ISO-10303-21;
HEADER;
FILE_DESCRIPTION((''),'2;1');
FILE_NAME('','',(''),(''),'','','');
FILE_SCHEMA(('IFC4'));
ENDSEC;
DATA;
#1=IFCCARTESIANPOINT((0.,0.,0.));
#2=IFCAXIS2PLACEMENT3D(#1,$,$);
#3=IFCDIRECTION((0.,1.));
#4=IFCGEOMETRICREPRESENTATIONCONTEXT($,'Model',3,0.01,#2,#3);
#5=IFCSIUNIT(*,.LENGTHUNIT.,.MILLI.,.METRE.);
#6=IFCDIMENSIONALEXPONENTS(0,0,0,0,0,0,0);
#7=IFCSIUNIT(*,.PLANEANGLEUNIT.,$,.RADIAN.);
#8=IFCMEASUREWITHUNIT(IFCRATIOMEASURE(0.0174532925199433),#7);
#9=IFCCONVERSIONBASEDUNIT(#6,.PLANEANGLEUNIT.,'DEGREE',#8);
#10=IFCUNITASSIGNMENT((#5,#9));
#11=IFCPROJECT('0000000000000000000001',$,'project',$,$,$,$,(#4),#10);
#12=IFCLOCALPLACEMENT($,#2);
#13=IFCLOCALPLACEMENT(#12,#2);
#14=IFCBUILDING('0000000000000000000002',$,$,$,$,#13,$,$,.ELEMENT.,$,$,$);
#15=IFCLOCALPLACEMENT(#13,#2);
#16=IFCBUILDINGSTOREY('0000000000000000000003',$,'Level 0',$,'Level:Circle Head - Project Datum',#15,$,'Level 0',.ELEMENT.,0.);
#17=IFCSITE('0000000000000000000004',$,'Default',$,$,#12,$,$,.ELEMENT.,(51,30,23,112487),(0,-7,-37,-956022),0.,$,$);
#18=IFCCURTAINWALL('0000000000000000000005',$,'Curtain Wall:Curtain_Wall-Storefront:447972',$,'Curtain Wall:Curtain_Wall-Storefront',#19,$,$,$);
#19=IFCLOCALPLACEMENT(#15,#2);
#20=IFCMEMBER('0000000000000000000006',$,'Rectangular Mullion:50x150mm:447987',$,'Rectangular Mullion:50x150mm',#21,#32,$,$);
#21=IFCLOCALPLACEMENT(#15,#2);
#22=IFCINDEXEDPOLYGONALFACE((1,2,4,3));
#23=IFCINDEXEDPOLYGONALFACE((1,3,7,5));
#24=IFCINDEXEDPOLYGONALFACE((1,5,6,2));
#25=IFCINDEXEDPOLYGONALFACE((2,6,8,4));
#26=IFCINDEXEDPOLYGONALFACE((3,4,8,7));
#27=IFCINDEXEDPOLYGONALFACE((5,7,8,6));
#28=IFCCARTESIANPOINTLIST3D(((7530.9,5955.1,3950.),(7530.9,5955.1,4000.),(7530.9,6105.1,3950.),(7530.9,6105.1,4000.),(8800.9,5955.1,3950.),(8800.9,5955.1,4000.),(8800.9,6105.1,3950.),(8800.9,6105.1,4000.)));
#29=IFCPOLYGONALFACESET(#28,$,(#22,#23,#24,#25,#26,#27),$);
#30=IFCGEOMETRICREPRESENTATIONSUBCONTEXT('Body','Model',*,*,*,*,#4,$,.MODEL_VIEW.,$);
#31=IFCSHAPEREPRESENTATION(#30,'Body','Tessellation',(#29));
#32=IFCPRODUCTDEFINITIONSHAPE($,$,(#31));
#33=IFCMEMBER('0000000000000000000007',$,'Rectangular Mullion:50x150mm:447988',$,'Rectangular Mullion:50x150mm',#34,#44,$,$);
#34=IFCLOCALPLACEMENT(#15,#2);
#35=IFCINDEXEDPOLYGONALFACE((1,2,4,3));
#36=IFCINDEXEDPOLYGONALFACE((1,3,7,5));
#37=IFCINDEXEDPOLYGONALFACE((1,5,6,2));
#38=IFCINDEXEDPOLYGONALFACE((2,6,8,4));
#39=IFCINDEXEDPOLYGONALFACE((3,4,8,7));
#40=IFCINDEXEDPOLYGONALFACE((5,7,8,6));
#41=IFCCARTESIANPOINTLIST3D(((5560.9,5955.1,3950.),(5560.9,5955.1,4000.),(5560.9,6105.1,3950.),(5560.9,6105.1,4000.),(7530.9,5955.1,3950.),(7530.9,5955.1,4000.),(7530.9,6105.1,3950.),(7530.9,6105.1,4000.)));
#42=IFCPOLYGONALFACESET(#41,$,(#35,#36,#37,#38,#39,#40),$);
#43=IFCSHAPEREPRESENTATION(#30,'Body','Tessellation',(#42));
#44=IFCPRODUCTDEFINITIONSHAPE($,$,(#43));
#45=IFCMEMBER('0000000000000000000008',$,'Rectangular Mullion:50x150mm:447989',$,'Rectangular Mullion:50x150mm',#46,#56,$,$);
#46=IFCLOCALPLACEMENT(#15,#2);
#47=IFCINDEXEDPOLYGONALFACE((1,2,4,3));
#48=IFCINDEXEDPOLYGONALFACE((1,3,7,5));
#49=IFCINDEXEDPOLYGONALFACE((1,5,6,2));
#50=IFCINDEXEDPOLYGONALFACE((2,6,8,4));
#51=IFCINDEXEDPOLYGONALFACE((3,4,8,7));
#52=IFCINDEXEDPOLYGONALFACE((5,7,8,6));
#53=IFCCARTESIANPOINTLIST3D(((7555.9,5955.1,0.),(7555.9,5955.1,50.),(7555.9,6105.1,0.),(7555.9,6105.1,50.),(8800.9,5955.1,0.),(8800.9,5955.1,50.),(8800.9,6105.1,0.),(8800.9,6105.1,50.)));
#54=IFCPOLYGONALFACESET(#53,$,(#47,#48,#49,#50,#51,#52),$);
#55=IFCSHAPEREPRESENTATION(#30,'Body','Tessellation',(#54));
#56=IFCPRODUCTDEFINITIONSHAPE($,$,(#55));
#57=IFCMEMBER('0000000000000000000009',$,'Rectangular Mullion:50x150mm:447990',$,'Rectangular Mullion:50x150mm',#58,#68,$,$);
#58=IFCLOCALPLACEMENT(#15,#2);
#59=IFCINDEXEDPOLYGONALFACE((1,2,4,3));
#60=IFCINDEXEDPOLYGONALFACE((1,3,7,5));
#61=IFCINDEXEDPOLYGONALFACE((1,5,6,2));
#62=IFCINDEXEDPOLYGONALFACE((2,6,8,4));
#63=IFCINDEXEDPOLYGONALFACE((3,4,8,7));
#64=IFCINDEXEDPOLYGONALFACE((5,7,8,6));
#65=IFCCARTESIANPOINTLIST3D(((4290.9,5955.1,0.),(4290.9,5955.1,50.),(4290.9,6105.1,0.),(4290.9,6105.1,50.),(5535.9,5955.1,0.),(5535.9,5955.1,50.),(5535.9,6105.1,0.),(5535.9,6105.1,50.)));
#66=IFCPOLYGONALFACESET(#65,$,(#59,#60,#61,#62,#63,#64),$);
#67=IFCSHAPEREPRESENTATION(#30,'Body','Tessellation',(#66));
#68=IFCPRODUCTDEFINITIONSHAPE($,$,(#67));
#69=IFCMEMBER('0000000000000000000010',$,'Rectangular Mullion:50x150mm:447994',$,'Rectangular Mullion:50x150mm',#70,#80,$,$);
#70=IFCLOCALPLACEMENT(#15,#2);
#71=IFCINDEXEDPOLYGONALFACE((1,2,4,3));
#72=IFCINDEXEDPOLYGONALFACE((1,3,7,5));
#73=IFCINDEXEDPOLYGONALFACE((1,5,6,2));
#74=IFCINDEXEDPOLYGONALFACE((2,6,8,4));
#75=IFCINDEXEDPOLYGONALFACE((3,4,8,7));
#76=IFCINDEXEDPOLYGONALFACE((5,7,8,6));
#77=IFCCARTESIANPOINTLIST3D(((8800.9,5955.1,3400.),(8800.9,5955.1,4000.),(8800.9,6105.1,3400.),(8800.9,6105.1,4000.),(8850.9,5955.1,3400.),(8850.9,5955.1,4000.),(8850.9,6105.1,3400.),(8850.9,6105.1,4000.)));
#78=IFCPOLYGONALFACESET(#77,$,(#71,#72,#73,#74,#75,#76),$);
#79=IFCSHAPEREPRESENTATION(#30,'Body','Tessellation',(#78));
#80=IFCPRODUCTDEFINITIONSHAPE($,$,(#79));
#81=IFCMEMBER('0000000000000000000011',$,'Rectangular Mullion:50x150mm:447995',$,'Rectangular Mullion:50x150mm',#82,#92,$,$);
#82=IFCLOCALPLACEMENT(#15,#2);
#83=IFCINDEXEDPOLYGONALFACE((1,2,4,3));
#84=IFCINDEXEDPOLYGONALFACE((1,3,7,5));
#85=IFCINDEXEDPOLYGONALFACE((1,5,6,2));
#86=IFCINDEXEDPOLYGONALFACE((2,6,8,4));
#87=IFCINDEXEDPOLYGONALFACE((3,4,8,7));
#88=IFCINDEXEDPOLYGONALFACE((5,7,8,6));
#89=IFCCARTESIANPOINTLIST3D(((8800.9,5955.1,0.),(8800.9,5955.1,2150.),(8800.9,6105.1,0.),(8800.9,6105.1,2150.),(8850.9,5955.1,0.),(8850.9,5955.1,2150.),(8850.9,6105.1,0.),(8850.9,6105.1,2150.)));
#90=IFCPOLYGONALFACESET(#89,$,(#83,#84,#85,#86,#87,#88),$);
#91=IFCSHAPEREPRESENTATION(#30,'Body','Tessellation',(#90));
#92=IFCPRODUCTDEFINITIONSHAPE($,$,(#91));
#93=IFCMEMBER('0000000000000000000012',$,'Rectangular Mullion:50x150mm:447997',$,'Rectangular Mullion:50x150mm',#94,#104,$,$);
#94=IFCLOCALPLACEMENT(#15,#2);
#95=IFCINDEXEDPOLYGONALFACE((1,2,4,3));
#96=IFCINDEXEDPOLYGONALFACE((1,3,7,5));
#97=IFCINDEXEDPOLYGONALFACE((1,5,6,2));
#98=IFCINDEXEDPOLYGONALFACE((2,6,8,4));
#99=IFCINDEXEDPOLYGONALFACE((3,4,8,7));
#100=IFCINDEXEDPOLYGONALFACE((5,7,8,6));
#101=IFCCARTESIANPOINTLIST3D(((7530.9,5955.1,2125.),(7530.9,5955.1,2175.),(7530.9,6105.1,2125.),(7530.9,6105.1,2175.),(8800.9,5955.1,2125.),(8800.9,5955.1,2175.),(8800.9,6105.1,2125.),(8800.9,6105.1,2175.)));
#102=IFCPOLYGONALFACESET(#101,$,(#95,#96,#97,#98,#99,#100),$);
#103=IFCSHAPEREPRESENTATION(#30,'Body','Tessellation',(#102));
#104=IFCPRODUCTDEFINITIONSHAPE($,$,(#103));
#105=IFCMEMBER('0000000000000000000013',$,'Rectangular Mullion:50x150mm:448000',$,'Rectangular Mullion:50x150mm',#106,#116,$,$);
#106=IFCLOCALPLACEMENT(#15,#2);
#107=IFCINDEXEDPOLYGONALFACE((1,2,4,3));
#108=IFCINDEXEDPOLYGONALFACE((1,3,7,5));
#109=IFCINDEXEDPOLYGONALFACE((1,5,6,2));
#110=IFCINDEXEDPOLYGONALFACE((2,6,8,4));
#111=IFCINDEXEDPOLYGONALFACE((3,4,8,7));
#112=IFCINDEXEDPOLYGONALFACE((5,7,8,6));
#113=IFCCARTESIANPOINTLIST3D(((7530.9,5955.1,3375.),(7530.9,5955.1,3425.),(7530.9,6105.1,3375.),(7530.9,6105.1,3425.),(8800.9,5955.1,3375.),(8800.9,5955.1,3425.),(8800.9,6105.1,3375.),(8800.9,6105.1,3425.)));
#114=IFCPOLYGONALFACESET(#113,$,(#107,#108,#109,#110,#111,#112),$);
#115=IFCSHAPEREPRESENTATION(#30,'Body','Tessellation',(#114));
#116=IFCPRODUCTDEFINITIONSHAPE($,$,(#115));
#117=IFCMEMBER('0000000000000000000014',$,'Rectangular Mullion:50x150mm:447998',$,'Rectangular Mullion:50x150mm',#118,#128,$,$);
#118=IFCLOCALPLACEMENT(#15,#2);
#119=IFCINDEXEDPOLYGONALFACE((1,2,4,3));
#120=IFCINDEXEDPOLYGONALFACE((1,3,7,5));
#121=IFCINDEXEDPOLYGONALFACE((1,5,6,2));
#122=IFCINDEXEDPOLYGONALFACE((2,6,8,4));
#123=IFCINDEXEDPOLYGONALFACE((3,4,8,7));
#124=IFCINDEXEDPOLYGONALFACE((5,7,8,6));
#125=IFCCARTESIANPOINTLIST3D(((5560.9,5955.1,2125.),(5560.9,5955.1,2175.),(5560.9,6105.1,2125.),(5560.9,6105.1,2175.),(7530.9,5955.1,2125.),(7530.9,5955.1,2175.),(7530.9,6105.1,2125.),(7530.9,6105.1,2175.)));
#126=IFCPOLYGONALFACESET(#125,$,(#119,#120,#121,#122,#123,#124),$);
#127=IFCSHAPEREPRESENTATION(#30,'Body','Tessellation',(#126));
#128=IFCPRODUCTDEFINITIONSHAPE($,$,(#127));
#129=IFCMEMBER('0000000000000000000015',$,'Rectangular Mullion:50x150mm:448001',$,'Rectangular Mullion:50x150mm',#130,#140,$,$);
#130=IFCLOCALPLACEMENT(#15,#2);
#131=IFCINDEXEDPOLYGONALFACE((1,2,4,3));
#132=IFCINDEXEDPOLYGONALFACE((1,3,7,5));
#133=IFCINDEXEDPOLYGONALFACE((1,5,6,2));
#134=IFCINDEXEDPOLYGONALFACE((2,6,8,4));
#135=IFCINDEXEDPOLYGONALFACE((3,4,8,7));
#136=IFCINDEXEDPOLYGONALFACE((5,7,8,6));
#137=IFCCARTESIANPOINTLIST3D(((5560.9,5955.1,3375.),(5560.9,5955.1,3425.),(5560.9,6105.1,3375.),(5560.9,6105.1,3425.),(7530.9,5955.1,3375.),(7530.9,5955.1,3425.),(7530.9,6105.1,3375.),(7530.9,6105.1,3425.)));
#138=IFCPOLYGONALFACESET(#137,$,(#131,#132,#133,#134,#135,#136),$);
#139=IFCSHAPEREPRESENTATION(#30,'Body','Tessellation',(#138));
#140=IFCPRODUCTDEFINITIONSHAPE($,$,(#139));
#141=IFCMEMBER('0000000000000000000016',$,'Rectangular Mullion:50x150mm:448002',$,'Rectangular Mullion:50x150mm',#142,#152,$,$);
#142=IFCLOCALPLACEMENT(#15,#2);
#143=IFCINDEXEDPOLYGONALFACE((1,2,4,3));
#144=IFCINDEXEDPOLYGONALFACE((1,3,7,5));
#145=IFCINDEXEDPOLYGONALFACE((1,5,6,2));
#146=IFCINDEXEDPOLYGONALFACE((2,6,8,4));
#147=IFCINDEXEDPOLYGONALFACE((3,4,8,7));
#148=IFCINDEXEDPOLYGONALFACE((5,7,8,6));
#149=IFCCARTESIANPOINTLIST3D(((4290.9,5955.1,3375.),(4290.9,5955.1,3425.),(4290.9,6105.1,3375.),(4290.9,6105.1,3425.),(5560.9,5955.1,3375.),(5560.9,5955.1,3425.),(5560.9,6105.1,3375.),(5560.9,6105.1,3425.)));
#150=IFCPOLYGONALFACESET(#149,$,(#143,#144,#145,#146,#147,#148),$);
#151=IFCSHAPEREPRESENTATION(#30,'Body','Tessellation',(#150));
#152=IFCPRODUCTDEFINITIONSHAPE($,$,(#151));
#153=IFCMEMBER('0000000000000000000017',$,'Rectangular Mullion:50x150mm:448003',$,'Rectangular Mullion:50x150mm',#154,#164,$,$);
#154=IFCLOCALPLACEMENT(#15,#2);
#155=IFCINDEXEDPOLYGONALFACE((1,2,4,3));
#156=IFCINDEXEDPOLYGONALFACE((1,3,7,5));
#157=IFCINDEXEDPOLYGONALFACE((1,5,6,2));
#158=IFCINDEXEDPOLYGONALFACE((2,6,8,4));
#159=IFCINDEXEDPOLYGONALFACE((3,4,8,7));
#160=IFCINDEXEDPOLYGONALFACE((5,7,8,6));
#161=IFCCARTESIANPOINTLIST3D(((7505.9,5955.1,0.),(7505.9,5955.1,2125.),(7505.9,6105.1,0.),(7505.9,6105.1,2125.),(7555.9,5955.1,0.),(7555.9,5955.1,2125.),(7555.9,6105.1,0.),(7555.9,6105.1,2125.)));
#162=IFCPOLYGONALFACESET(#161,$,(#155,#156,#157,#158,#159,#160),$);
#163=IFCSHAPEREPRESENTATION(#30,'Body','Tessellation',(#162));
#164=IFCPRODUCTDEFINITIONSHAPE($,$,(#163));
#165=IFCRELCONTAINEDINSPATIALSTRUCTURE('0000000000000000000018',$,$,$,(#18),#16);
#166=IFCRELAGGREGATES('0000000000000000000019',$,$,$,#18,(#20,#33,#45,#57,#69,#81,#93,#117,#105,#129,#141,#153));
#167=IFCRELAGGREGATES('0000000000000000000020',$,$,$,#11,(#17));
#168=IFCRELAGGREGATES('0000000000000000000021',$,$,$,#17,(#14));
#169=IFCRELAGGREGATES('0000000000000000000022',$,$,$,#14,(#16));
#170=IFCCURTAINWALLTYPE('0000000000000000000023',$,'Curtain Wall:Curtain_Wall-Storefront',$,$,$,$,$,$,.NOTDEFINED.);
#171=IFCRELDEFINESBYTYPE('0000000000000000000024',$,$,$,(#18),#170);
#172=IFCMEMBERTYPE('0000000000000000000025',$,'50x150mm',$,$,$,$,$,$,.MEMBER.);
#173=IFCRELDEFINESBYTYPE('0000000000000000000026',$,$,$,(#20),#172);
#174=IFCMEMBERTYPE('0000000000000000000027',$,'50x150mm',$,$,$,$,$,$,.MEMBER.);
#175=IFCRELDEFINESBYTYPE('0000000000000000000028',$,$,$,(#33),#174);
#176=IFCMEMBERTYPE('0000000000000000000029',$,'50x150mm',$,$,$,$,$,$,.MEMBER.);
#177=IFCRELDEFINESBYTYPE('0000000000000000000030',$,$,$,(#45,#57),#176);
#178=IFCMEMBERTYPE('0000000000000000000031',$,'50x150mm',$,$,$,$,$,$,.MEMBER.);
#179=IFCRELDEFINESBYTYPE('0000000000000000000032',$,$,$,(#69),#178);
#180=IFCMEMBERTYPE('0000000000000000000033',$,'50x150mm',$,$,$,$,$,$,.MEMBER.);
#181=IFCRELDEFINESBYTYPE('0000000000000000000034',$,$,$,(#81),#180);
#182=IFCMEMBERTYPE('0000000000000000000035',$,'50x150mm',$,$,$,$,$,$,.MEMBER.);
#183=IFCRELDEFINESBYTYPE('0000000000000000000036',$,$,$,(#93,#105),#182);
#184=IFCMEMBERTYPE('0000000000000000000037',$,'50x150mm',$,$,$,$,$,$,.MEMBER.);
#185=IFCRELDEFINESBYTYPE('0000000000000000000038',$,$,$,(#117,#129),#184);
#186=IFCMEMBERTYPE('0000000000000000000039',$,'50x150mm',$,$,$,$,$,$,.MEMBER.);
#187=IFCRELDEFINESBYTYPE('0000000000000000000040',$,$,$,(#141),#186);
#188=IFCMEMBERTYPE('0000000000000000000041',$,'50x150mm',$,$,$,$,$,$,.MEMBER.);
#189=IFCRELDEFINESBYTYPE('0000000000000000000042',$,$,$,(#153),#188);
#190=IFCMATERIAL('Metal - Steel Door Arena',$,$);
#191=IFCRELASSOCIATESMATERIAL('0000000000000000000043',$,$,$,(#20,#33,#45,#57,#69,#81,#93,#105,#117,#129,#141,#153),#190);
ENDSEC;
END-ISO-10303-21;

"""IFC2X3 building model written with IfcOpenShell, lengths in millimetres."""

from ifc_helpers import new_model, entity, si_unit, converted_unit, direction, frame, origin, origin_2d_with_axis, place, context, subcontext, project, spatial, rectangle, extrude, source, transform, mapped, material, type_object, type_shapes, element, aggregate, save


model = new_model("IFC2X3")

# Units and contexts
model_context = context("Model", 3, precision=0.01, world=origin(), true_north=direction((0.0, 1.0)))
body_context = subcontext(model_context, "Body", "Model", "MODEL_VIEW")
ifc_project = project(units=[si_unit("LENGTHUNIT", "METRE", prefix="MILLI"), converted_unit("PLANEANGLEUNIT", "DEGREE", entity("IfcRatioMeasure", 0.0174532925199433), si_unit("PLANEANGLEUNIT", "RADIAN"), dimensions=[0, 0, 0, 0, 0, 0, 0])], contexts=[model_context])

# Site, building, storey
site_placement = place(None, origin())
site = spatial("IfcSite", under=ifc_project, at=site_placement, Name="Default", CompositionType="ELEMENT", RefLatitude=(51, 30, 23, 112487), RefLongitude=(0, -7, -37, -956022), RefElevation=0.0)
building_placement = place(site_placement, origin())
building = spatial("IfcBuilding", under=site, at=building_placement, CompositionType="ELEMENT")
storey_placement = place(building_placement, origin())
storey = spatial("IfcBuildingStorey", under=building, at=storey_placement, Name="Level 0", ObjectType="Level:Circle Head - Project Datum", LongName="Level 0", CompositionType="ELEMENT", Elevation=0.0)

# Curtain wall, members
curtain_wall_type = type_object("IfcCurtainWallType", Name="Curtain Wall:Curtain_Wall-Storefront", PredefinedType="NOTDEFINED")
curtain_wall_placement = place(storey_placement, origin())
curtain_wall = element("IfcCurtainWall", 1, at=curtain_wall_placement, inside=storey, type_object=curtain_wall_type, Name="Curtain Wall:Curtain_Wall-Storefront:447972", ObjectType="Curtain Wall:Curtain_Wall-Storefront")
ifc_material_1 = material(Name="Metal - Steel Door Arena")
member_type_1 = type_object("IfcMemberType", Name="50x150mm", PredefinedType="MEMBER")
shared_shape_1 = source(origin(), body_context, "Body", "SweptSolid", [
    extrude(rectangle(XDim=150.0, YDim=50.0, at=origin_2d_with_axis()), frame((-25.0, 0.0, -1270.0), z_axis=(0.0, 0.0, 1.0), x_axis=(0.0, -1.0, 0.0)), (0.0, 0.0, 1.0), 1270.0),
])
type_shapes(member_type_1, [shared_shape_1])
member_1_placement = place(storey_placement, frame((7530.9, 6030.1, 4000.0), z_axis=(-1.0, 0.0, 0.0), x_axis=(0.0, 0.0, 1.0)))
member_1 = element("IfcMember", 2, at=member_1_placement, type_object=member_type_1, material=ifc_material_1, Name="Rectangular Mullion:50x150mm:447987", ObjectType="Rectangular Mullion:50x150mm", context=body_context, shape_type="MappedRepresentation", body=[
    mapped(shared_shape_1, transform((0.0, 0.0, 0.0), scale=1.0)),
])
member_type_2 = type_object("IfcMemberType", Name="50x150mm", PredefinedType="MEMBER")
shared_shape_2 = source(origin(), body_context, "Body", "SweptSolid", [
    extrude(rectangle(XDim=150.0, YDim=50.0, at=origin_2d_with_axis()), frame((-25.0, 0.0, -1970.0), z_axis=(0.0, 0.0, 1.0), x_axis=(0.0, -1.0, 0.0)), (0.0, 0.0, 1.0), 1970.0),
])
type_shapes(member_type_2, [shared_shape_2])
member_2_placement = place(storey_placement, frame((5560.9, 6030.1, 4000.0), z_axis=(-1.0, 0.0, 0.0), x_axis=(0.0, 0.0, 1.0)))
member_2 = element("IfcMember", 3, at=member_2_placement, type_object=member_type_2, material=ifc_material_1, Name="Rectangular Mullion:50x150mm:447988", ObjectType="Rectangular Mullion:50x150mm", context=body_context, shape_type="MappedRepresentation", body=[
    mapped(shared_shape_2, transform((0.0, 0.0, 0.0), scale=1.0)),
])
member_type_3 = type_object("IfcMemberType", Name="50x150mm", PredefinedType="MEMBER")
shared_shape_3 = source(origin(), body_context, "Body", "SweptSolid", [
    extrude(rectangle(XDim=150.0, YDim=50.0, at=origin_2d_with_axis()), frame((-25.0, 0.0, -1245.0), z_axis=(0.0, 0.0, 1.0), x_axis=(0.0, -1.0, 0.0)), (0.0, 0.0, 1.0), 1245.0),
])
type_shapes(member_type_3, [shared_shape_3])
member_3_placement = place(storey_placement, frame((8800.9, 6030.1, 0.0), z_axis=(1.0, 0.0, 0.0), x_axis=(0.0, 0.0, -1.0)))
member_3 = element("IfcMember", 4, at=member_3_placement, type_object=member_type_3, material=ifc_material_1, Name="Rectangular Mullion:50x150mm:447989", ObjectType="Rectangular Mullion:50x150mm", context=body_context, shape_type="MappedRepresentation", body=[
    mapped(shared_shape_3, transform((0.0, 0.0, 0.0), scale=1.0)),
])
member_4_placement = place(storey_placement, frame((5535.9, 6030.1, 0.0), z_axis=(1.0, 0.0, 0.0), x_axis=(0.0, 0.0, -1.0)))
member_4 = element("IfcMember", 5, at=member_4_placement, type_object=member_type_3, material=ifc_material_1, Name="Rectangular Mullion:50x150mm:447990", ObjectType="Rectangular Mullion:50x150mm", context=body_context, shape_type="MappedRepresentation", body=[
    mapped(shared_shape_3, transform((0.0, 0.0, 0.0), scale=1.0)),
])
member_type_4 = type_object("IfcMemberType", Name="50x150mm", PredefinedType="MEMBER")
shared_shape_4 = source(origin(), body_context, "Body", "SweptSolid", [
    extrude(rectangle(XDim=150.0, YDim=50.0, at=origin_2d_with_axis()), frame((-25.0, 0.0, -600.0), z_axis=(0.0, 0.0, 1.0), x_axis=(0.0, -1.0, 0.0)), (0.0, 0.0, 1.0), 600.0),
])
type_shapes(member_type_4, [shared_shape_4])
member_5_placement = place(storey_placement, frame((8850.9, 6030.1, 4000.0)))
member_5 = element("IfcMember", 6, at=member_5_placement, type_object=member_type_4, material=ifc_material_1, Name="Rectangular Mullion:50x150mm:447994", ObjectType="Rectangular Mullion:50x150mm", context=body_context, shape_type="MappedRepresentation", body=[
    mapped(shared_shape_4, transform((0.0, 0.0, 0.0), scale=1.0)),
])
member_type_5 = type_object("IfcMemberType", Name="50x150mm", PredefinedType="MEMBER")
shared_shape_5 = source(origin(), body_context, "Body", "SweptSolid", [
    extrude(rectangle(XDim=150.0, YDim=50.0, at=origin_2d_with_axis()), frame((-25.0, 0.0, -2150.0), z_axis=(0.0, 0.0, 1.0), x_axis=(0.0, -1.0, 0.0)), (0.0, 0.0, 1.0), 2150.0),
])
type_shapes(member_type_5, [shared_shape_5])
member_6_placement = place(storey_placement, frame((8850.9, 6030.1, 2150.0)))
member_6 = element("IfcMember", 7, at=member_6_placement, type_object=member_type_5, material=ifc_material_1, Name="Rectangular Mullion:50x150mm:447995", ObjectType="Rectangular Mullion:50x150mm", context=body_context, shape_type="MappedRepresentation", body=[
    mapped(shared_shape_5, transform((0.0, 0.0, 0.0), scale=1.0)),
])
member_type_6 = type_object("IfcMemberType", Name="50x150mm", PredefinedType="MEMBER")
shared_shape_6 = source(origin(), body_context, "Body", "SweptSolid", [
    extrude(rectangle(XDim=150.0, YDim=50.0, at=origin_2d_with_axis()), frame((0.0, 0.0, -1270.0), z_axis=(0.0, 0.0, 1.0), x_axis=(0.0, -1.0, 0.0)), (0.0, 0.0, 1.0), 1270.0),
])
type_shapes(member_type_6, [shared_shape_6])
member_7_placement = place(storey_placement, frame((7530.9, 6030.1, 2150.0), z_axis=(-1.0, 0.0, 0.0), x_axis=(0.0, 0.0, 1.0)))
member_7 = element("IfcMember", 8, at=member_7_placement, type_object=member_type_6, material=ifc_material_1, Name="Rectangular Mullion:50x150mm:447997", ObjectType="Rectangular Mullion:50x150mm", context=body_context, shape_type="MappedRepresentation", body=[
    mapped(shared_shape_6, transform((0.0, 0.0, 0.0), scale=1.0)),
])
member_8_placement = place(storey_placement, frame((7530.9, 6030.1, 3400.0), z_axis=(-1.0, 0.0, 0.0), x_axis=(0.0, 0.0, 1.0)))
member_8 = element("IfcMember", 9, at=member_8_placement, type_object=member_type_6, material=ifc_material_1, Name="Rectangular Mullion:50x150mm:448000", ObjectType="Rectangular Mullion:50x150mm", context=body_context, shape_type="MappedRepresentation", body=[
    mapped(shared_shape_6, transform((0.0, 0.0, 0.0), scale=1.0)),
])
member_type_7 = type_object("IfcMemberType", Name="50x150mm", PredefinedType="MEMBER")
shared_shape_7 = source(origin(), body_context, "Body", "SweptSolid", [
    extrude(rectangle(XDim=150.0, YDim=50.0, at=origin_2d_with_axis()), frame((0.0, 0.0, -1970.0), z_axis=(0.0, 0.0, 1.0), x_axis=(0.0, -1.0, 0.0)), (0.0, 0.0, 1.0), 1970.0),
])
type_shapes(member_type_7, [shared_shape_7])
member_9_placement = place(storey_placement, frame((5560.9, 6030.1, 2150.0), z_axis=(-1.0, 0.0, 0.0), x_axis=(0.0, 0.0, 1.0)))
member_9 = element("IfcMember", 10, at=member_9_placement, type_object=member_type_7, material=ifc_material_1, Name="Rectangular Mullion:50x150mm:447998", ObjectType="Rectangular Mullion:50x150mm", context=body_context, shape_type="MappedRepresentation", body=[
    mapped(shared_shape_7, transform((0.0, 0.0, 0.0), scale=1.0)),
])
member_10_placement = place(storey_placement, frame((5560.9, 6030.1, 3400.0), z_axis=(-1.0, 0.0, 0.0), x_axis=(0.0, 0.0, 1.0)))
member_10 = element("IfcMember", 11, at=member_10_placement, type_object=member_type_7, material=ifc_material_1, Name="Rectangular Mullion:50x150mm:448001", ObjectType="Rectangular Mullion:50x150mm", context=body_context, shape_type="MappedRepresentation", body=[
    mapped(shared_shape_7, transform((0.0, 0.0, 0.0), scale=1.0)),
])
member_type_8 = type_object("IfcMemberType", Name="50x150mm", PredefinedType="MEMBER")
shared_shape_8 = source(origin(), body_context, "Body", "SweptSolid", [
    extrude(rectangle(XDim=150.0, YDim=50.0, at=origin_2d_with_axis()), frame((0.0, 0.0, -1270.0), z_axis=(0.0, 0.0, 1.0), x_axis=(0.0, -1.0, 0.0)), (0.0, 0.0, 1.0), 1270.0),
])
type_shapes(member_type_8, [shared_shape_8])
member_11_placement = place(storey_placement, frame((4290.9, 6030.1, 3400.0), z_axis=(-1.0, 0.0, 0.0), x_axis=(0.0, 0.0, 1.0)))
member_11 = element("IfcMember", 12, at=member_11_placement, type_object=member_type_8, material=ifc_material_1, Name="Rectangular Mullion:50x150mm:448002", ObjectType="Rectangular Mullion:50x150mm", context=body_context, shape_type="MappedRepresentation", body=[
    mapped(shared_shape_8, transform((0.0, 0.0, 0.0), scale=1.0)),
])
member_type_9 = type_object("IfcMemberType", Name="50x150mm", PredefinedType="MEMBER")
shared_shape_9 = source(origin(), body_context, "Body", "SweptSolid", [
    extrude(rectangle(XDim=150.0, YDim=50.0, at=origin_2d_with_axis()), frame((0.0, 0.0, -2125.0), z_axis=(0.0, 0.0, 1.0), x_axis=(0.0, -1.0, 0.0)), (0.0, 0.0, 1.0), 2125.0),
])
type_shapes(member_type_9, [shared_shape_9])
member_12_placement = place(storey_placement, frame((7530.9, 6030.1, 0.0), z_axis=(0.0, 0.0, -1.0), x_axis=(-1.0, 0.0, 0.0)))
member_12 = element("IfcMember", 13, at=member_12_placement, type_object=member_type_9, material=ifc_material_1, Name="Rectangular Mullion:50x150mm:448003", ObjectType="Rectangular Mullion:50x150mm", context=body_context, shape_type="MappedRepresentation", body=[
    mapped(shared_shape_9, transform((0.0, 0.0, 0.0), scale=1.0)),
])
aggregate(curtain_wall, [member_1, member_2, member_3, member_4, member_5, member_6, member_7, member_9, member_8, member_10, member_11, member_12])

save(model, "model.ifc")
